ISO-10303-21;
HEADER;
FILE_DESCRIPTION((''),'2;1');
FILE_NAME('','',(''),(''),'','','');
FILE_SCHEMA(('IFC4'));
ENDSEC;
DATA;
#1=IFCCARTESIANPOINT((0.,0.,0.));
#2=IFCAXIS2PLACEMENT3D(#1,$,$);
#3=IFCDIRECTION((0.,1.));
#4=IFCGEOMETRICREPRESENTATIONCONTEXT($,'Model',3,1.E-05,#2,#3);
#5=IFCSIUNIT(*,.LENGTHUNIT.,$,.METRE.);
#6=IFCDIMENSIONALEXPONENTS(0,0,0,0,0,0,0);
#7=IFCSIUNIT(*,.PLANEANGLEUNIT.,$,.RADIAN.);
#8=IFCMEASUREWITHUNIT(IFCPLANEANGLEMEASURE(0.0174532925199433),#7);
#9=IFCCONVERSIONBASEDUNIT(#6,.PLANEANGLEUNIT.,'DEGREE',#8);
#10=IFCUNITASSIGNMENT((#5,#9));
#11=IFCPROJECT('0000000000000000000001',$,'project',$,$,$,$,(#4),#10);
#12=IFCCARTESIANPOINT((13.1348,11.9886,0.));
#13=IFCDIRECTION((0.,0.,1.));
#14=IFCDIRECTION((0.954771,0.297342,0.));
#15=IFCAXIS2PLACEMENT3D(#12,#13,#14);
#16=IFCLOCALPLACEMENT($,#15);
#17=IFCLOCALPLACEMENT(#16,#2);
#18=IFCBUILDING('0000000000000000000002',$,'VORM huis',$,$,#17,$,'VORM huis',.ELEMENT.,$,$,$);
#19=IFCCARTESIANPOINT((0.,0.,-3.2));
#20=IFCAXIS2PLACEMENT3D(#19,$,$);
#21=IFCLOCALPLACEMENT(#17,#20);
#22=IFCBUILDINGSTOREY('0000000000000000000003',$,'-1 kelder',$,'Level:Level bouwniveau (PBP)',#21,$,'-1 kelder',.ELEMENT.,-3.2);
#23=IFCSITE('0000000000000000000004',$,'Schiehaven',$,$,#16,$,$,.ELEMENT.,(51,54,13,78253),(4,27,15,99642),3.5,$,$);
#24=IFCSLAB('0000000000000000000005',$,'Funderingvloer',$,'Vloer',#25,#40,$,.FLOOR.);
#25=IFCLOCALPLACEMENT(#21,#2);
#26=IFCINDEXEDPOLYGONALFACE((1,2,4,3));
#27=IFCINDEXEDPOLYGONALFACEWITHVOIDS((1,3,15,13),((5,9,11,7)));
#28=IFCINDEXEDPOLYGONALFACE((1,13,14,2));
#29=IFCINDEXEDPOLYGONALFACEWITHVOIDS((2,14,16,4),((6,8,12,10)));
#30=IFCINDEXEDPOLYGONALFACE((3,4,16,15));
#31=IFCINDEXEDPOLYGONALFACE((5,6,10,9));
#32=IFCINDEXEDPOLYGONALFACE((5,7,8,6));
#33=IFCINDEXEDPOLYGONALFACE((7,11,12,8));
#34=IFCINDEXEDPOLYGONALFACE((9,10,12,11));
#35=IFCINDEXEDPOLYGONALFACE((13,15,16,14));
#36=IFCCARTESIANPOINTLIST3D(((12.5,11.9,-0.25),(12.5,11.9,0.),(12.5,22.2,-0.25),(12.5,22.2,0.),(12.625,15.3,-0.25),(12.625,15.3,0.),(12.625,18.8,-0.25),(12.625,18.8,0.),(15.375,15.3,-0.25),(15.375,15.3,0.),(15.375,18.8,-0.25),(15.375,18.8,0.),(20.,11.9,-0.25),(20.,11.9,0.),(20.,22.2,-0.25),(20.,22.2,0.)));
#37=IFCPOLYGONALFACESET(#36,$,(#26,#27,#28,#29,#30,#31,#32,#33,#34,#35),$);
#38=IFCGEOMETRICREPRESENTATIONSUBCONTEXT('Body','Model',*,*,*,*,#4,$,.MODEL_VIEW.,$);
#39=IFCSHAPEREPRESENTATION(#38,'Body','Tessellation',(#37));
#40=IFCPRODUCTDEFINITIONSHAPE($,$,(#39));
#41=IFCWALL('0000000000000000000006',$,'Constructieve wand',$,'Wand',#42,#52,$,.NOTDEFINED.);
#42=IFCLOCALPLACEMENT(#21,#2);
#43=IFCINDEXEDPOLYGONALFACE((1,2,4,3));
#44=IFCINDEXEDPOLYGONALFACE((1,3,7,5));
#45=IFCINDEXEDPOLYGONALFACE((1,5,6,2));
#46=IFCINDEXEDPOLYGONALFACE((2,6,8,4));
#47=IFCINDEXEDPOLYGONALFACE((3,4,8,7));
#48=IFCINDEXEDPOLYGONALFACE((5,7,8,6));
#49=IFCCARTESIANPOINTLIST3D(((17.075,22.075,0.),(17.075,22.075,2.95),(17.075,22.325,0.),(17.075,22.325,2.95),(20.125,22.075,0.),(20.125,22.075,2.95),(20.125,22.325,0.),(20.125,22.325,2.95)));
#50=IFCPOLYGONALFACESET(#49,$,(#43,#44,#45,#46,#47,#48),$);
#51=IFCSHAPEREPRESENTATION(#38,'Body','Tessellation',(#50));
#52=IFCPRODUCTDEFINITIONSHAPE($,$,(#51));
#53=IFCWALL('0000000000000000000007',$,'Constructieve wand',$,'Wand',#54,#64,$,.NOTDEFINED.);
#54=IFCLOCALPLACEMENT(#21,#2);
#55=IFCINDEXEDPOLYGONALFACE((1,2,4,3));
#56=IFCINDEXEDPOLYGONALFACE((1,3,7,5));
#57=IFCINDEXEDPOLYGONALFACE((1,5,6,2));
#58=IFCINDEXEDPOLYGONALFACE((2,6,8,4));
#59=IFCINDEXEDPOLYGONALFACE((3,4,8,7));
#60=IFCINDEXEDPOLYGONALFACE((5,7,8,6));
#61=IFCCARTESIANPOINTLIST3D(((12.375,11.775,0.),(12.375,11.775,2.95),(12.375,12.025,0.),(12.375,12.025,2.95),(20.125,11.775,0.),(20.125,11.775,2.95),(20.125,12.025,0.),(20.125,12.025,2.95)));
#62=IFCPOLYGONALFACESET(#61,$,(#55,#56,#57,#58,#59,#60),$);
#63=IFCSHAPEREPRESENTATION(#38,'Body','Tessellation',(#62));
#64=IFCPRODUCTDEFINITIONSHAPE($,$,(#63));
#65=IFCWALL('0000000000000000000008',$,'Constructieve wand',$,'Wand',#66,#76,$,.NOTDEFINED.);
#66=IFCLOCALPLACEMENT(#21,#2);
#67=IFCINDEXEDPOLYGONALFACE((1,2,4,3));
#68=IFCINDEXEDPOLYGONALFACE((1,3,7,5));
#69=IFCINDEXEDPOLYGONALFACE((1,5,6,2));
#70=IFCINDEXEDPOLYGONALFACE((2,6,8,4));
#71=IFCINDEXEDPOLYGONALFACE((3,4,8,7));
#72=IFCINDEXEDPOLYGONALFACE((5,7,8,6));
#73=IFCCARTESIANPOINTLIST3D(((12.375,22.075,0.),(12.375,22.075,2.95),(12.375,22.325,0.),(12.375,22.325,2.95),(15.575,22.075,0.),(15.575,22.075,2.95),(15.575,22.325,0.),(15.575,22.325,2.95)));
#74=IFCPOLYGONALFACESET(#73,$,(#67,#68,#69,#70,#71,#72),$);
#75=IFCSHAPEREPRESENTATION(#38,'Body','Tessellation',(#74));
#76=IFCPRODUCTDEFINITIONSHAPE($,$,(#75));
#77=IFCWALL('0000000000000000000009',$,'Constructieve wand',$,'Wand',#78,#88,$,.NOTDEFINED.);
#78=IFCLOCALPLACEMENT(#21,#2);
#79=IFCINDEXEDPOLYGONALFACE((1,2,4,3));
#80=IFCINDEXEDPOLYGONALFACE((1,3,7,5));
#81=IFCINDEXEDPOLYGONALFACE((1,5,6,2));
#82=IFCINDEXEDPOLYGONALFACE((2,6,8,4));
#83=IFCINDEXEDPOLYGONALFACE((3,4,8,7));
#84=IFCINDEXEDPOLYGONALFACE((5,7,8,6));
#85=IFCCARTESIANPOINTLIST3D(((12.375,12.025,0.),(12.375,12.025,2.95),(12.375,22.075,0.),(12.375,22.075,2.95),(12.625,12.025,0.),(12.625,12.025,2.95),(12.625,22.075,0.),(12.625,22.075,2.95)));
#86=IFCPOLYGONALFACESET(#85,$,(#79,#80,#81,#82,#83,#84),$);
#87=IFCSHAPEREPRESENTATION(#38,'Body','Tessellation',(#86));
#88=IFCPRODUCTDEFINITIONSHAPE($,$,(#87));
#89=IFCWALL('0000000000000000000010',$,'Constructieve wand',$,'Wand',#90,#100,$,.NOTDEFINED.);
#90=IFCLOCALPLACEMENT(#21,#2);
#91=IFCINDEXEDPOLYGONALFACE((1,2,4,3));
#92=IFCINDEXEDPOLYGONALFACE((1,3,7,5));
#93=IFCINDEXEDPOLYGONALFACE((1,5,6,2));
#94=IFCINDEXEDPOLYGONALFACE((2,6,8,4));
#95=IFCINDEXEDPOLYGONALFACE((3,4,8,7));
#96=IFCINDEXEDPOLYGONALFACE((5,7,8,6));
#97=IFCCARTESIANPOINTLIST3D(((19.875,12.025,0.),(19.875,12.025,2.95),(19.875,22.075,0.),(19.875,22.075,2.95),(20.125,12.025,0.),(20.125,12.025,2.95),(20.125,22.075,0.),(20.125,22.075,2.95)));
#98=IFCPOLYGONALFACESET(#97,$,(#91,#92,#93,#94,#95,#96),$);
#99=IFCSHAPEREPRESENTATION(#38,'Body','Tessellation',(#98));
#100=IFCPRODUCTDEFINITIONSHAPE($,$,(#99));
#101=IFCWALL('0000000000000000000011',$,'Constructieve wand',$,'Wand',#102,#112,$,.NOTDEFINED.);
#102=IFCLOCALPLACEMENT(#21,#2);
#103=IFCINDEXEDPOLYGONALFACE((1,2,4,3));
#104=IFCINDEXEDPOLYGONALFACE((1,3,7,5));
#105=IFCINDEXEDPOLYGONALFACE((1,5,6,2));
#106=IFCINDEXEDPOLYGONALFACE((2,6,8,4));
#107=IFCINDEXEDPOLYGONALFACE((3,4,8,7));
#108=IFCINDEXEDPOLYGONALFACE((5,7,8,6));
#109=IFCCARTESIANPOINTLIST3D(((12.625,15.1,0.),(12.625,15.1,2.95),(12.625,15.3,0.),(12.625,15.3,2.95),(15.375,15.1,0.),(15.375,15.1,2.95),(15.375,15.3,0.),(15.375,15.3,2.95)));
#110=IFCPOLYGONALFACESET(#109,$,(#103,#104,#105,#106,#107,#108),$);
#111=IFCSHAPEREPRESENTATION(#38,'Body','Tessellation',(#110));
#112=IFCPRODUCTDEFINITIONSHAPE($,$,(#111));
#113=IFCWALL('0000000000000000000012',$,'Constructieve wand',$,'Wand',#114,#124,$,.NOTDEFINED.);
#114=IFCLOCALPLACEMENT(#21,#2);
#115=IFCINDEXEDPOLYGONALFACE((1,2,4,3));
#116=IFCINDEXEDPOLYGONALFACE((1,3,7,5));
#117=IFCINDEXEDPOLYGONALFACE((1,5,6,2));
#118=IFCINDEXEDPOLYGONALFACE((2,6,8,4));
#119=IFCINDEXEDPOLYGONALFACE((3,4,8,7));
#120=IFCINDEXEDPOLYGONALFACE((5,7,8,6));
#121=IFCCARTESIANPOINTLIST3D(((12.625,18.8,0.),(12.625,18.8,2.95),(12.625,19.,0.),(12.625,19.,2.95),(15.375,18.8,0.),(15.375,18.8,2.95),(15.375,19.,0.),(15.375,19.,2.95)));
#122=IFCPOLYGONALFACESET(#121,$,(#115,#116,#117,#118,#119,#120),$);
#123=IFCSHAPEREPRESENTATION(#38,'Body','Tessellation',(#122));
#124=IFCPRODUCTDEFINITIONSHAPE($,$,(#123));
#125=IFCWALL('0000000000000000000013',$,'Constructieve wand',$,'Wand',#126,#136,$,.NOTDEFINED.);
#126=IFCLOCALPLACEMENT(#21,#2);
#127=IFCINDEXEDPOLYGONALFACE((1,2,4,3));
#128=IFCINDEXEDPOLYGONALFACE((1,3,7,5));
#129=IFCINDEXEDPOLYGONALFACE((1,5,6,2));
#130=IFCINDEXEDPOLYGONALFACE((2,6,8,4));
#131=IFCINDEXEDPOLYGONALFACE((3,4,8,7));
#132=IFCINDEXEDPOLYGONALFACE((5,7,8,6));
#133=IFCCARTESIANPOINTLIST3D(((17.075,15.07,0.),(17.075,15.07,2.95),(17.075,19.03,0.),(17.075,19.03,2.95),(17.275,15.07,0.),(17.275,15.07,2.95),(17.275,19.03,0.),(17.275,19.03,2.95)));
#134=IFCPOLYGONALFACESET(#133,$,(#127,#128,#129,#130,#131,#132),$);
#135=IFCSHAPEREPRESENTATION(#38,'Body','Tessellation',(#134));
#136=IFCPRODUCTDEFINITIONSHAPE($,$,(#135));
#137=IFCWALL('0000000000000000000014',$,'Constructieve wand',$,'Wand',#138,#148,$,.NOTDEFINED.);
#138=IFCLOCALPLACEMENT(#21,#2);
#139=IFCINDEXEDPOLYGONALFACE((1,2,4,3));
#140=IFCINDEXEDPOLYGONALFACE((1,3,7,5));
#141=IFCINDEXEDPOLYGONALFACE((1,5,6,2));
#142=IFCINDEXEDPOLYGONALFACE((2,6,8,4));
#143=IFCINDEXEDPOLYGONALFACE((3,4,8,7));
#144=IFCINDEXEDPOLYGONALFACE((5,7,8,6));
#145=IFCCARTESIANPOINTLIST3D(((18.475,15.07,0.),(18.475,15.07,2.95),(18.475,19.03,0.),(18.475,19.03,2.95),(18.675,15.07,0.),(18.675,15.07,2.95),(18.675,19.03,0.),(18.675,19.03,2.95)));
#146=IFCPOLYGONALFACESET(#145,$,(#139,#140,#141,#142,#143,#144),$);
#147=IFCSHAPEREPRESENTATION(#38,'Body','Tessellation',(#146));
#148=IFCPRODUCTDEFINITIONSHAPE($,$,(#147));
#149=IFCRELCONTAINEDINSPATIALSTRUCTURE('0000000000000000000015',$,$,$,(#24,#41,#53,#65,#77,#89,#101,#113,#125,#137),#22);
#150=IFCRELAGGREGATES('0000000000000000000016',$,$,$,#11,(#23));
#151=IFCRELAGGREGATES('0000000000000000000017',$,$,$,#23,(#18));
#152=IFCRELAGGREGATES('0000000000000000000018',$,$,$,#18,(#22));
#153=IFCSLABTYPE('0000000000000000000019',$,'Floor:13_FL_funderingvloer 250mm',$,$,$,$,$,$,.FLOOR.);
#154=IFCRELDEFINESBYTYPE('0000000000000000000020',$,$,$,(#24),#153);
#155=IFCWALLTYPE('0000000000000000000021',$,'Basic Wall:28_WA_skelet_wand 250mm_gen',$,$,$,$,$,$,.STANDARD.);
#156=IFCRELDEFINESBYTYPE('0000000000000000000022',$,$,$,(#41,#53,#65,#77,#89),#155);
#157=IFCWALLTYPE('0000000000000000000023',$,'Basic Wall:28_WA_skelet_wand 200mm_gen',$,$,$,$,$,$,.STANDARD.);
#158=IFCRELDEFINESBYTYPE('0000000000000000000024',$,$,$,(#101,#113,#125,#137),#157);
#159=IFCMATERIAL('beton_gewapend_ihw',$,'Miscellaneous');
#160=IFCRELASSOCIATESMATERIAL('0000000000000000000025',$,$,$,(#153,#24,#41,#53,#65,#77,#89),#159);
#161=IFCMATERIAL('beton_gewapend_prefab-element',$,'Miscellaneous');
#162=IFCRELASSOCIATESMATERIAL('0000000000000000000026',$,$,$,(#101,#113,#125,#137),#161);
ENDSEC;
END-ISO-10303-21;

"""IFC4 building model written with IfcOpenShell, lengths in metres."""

from ifc_helpers import new_model, entity, si_unit, converted_unit, direction, frame, origin, place, context, subcontext, project, spatial, indexed_curve, outline, extrude, material, type_object, element, save


model = new_model("IFC4")

# Units and contexts
model_context = context("Model", 3, precision=1e-05, world=origin(), true_north=direction((0.0, 1.0)))
body_context = subcontext(model_context, "Body", "Model", "MODEL_VIEW")
ifc_project = project(units=[si_unit("LENGTHUNIT", "METRE"), converted_unit("PLANEANGLEUNIT", "DEGREE", entity("IfcPlaneAngleMeasure", 0.0174532925199433), si_unit("PLANEANGLEUNIT", "RADIAN"), dimensions=[0, 0, 0, 0, 0, 0, 0])], contexts=[model_context])

# Site, building, storey
site_placement = place(None, frame((13.1348, 11.9886, 0.0), z_axis=(0.0, 0.0, 1.0), x_axis=(0.954771, 0.297342, 0.0)))
site = spatial("IfcSite", under=ifc_project, at=site_placement, Name="Schiehaven", CompositionType="ELEMENT", RefLatitude=(51, 54, 13, 78253), RefLongitude=(4, 27, 15, 99642), RefElevation=3.5)
building_placement = place(site_placement, origin())
building = spatial("IfcBuilding", under=site, at=building_placement, Name="VORM huis", LongName="VORM huis", CompositionType="ELEMENT")
storey_placement = place(building_placement, frame((0.0, 0.0, -3.2)))
storey = spatial("IfcBuildingStorey", under=building, at=storey_placement, Name="-1 kelder", ObjectType="Level:Level bouwniveau (PBP)", LongName="-1 kelder", CompositionType="ELEMENT", Elevation=-3.2)

# Slab, opening
ifc_material_1 = material(Name="beton_gewapend_ihw", Category="Miscellaneous")
slab_type = type_object("IfcSlabType", Name="Floor:13_FL_funderingvloer 250mm", PredefinedType="FLOOR", material=ifc_material_1)
slab_placement = place(storey_placement, origin())
slab = element("IfcSlab", 1, at=slab_placement, inside=storey, type_object=slab_type, material=ifc_material_1, Name="Funderingvloer", ObjectType="Vloer", PredefinedType="FLOOR", context=body_context, shape_type="SweptSolid", body=[
    extrude(outline(indexed_curve([(-3.75, -5.15), (3.75, -5.15), (3.75, 5.15), (-3.75, 5.15), (-3.75, -5.15)], self_intersect=False), holes=[indexed_curve([(3.625, -1.75), (0.875, -1.75), (0.875, 1.75), (3.625, 1.75), (3.625, -1.75)], self_intersect=False)]), frame((16.25, 17.05, -0.25), z_axis=(0.0, 0.0, 1.0), x_axis=(-1.0, 0.0, 0.0)), (0.0, 0.0, 1.0), 0.25),
])
opening_placement = place(slab_placement, origin())
element("IfcOpeningElement", 2, at=opening_placement, cuts=slab, PredefinedType="OPENING", context=body_context, shape_type="SweptSolid", body=[
    extrude(outline(indexed_curve([(-1.75, -1.375), (1.75, -1.375), (1.75, 1.375), (-1.75, 1.375), (-1.75, -1.375)], self_intersect=False)), frame((14.0, 17.05, -0.25), z_axis=(0.0, 0.0, 1.0), x_axis=(0.0, -1.0, 0.0)), (0.0, 0.0, 1.0), 0.25),
])

# Walls
wall_type_1 = type_object("IfcWallType", Name="Basic Wall:28_WA_skelet_wand 250mm_gen", PredefinedType="STANDARD")
wall_1_placement = place(storey_placement, frame((20.125, 22.2, 0.0), z_axis=(0.0, 0.0, 1.0), x_axis=(-1.0, 0.0, 0.0)))
element("IfcWall", 3, at=wall_1_placement, inside=storey, type_object=wall_type_1, material=ifc_material_1, Name="Constructieve wand", ObjectType="Wand", PredefinedType="NOTDEFINED", context=body_context, shape_type="SweptSolid", body=[
    extrude(outline(indexed_curve([(3.05, 0.125), (0.0, 0.125), (0.0, -0.125), (3.05, -0.125), (3.05, 0.125)], self_intersect=False)), origin(), (0.0, 0.0, 1.0), 2.95),
])
wall_2_placement = place(storey_placement, frame((20.125, 11.9, 0.0), z_axis=(0.0, 0.0, 1.0), x_axis=(-1.0, 0.0, 0.0)))
element("IfcWall", 4, at=wall_2_placement, inside=storey, type_object=wall_type_1, material=ifc_material_1, Name="Constructieve wand", ObjectType="Wand", PredefinedType="NOTDEFINED", context=body_context, shape_type="SweptSolid", body=[
    extrude(outline(indexed_curve([(7.75, 0.125), (0.0, 0.125), (0.0, -0.125), (7.75, -0.125), (7.75, 0.125)], self_intersect=False)), origin(), (0.0, 0.0, 1.0), 2.95),
])
wall_3_placement = place(storey_placement, frame((15.575, 22.2, 0.0), z_axis=(0.0, 0.0, 1.0), x_axis=(-1.0, 0.0, 0.0)))
element("IfcWall", 5, at=wall_3_placement, inside=storey, type_object=wall_type_1, material=ifc_material_1, Name="Constructieve wand", ObjectType="Wand", PredefinedType="NOTDEFINED", context=body_context, shape_type="SweptSolid", body=[
    extrude(outline(indexed_curve([(3.2, 0.125), (0.0, 0.125), (0.0, -0.125), (3.2, -0.125), (3.2, 0.125)], self_intersect=False)), origin(), (0.0, 0.0, 1.0), 2.95),
])
wall_4_placement = place(storey_placement, frame((12.5, 12.025, 0.0), z_axis=(0.0, 0.0, 1.0), x_axis=(0.0, 1.0, 0.0)))
element("IfcWall", 6, at=wall_4_placement, inside=storey, type_object=wall_type_1, material=ifc_material_1, Name="Constructieve wand", ObjectType="Wand", PredefinedType="NOTDEFINED", context=body_context, shape_type="SweptSolid", body=[
    extrude(outline(indexed_curve([(10.05, 0.125), (0.0, 0.125), (0.0, -0.125), (10.05, -0.125), (10.05, 0.125)], self_intersect=False)), origin(), (0.0, 0.0, 1.0), 2.95),
])
wall_5_placement = place(storey_placement, frame((20.0, 22.075, 0.0), z_axis=(0.0, 0.0, 1.0), x_axis=(0.0, -1.0, 0.0)))
element("IfcWall", 7, at=wall_5_placement, inside=storey, type_object=wall_type_1, material=ifc_material_1, Name="Constructieve wand", ObjectType="Wand", PredefinedType="NOTDEFINED", context=body_context, shape_type="SweptSolid", body=[
    extrude(outline(indexed_curve([(10.05, 0.125), (0.0, 0.125), (0.0, -0.125), (10.05, -0.125), (10.05, 0.125)], self_intersect=False)), origin(), (0.0, 0.0, 1.0), 2.95),
])
ifc_material_2 = material(Name="beton_gewapend_prefab-element", Category="Miscellaneous")
wall_type_2 = type_object("IfcWallType", Name="Basic Wall:28_WA_skelet_wand 200mm_gen", PredefinedType="STANDARD")
wall_6_placement = place(storey_placement, frame((12.625, 15.2, 0.0)))
element("IfcWall", 8, at=wall_6_placement, inside=storey, type_object=wall_type_2, material=ifc_material_2, Name="Constructieve wand", ObjectType="Wand", PredefinedType="NOTDEFINED", context=body_context, shape_type="SweptSolid", body=[
    extrude(outline(indexed_curve([(2.75, 0.1), (0.0, 0.1), (0.0, -0.1), (2.75, -0.1), (2.75, 0.1)], self_intersect=False)), origin(), (0.0, 0.0, 1.0), 2.95),
])
wall_7_placement = place(storey_placement, frame((15.375, 18.9, 0.0), z_axis=(0.0, 0.0, 1.0), x_axis=(-1.0, 0.0, 0.0)))
element("IfcWall", 9, at=wall_7_placement, inside=storey, type_object=wall_type_2, material=ifc_material_2, Name="Constructieve wand", ObjectType="Wand", PredefinedType="NOTDEFINED", context=body_context, shape_type="SweptSolid", body=[
    extrude(outline(indexed_curve([(2.75, 0.1), (0.0, 0.1), (0.0, -0.1), (2.75, -0.1), (2.75, 0.1)], self_intersect=False)), origin(), (0.0, 0.0, 1.0), 2.95),
])
wall_8_placement = place(storey_placement, frame((17.175, 15.07, 0.0), z_axis=(0.0, 0.0, 1.0), x_axis=(0.0, 1.0, 0.0)))
element("IfcWall", 10, at=wall_8_placement, inside=storey, type_object=wall_type_2, material=ifc_material_2, Name="Constructieve wand", ObjectType="Wand", PredefinedType="NOTDEFINED", context=body_context, shape_type="SweptSolid", body=[
    extrude(outline(indexed_curve([(3.96, 0.1), (0.0, 0.1), (0.0, -0.1), (3.96, -0.1), (3.96, 0.1)], self_intersect=False)), origin(), (0.0, 0.0, 1.0), 2.95),
])
wall_9_placement = place(storey_placement, frame((18.575, 15.07, 0.0), z_axis=(0.0, 0.0, 1.0), x_axis=(0.0, 1.0, 0.0)))
element("IfcWall", 11, at=wall_9_placement, inside=storey, type_object=wall_type_2, material=ifc_material_2, Name="Constructieve wand", ObjectType="Wand", PredefinedType="NOTDEFINED", context=body_context, shape_type="SweptSolid", body=[
    extrude(outline(indexed_curve([(3.96, 0.1), (0.0, 0.1), (0.0, -0.1), (3.96, -0.1), (3.96, 0.1)], self_intersect=False)), origin(), (0.0, 0.0, 1.0), 2.95),
])

save(model, "model.ifc")
